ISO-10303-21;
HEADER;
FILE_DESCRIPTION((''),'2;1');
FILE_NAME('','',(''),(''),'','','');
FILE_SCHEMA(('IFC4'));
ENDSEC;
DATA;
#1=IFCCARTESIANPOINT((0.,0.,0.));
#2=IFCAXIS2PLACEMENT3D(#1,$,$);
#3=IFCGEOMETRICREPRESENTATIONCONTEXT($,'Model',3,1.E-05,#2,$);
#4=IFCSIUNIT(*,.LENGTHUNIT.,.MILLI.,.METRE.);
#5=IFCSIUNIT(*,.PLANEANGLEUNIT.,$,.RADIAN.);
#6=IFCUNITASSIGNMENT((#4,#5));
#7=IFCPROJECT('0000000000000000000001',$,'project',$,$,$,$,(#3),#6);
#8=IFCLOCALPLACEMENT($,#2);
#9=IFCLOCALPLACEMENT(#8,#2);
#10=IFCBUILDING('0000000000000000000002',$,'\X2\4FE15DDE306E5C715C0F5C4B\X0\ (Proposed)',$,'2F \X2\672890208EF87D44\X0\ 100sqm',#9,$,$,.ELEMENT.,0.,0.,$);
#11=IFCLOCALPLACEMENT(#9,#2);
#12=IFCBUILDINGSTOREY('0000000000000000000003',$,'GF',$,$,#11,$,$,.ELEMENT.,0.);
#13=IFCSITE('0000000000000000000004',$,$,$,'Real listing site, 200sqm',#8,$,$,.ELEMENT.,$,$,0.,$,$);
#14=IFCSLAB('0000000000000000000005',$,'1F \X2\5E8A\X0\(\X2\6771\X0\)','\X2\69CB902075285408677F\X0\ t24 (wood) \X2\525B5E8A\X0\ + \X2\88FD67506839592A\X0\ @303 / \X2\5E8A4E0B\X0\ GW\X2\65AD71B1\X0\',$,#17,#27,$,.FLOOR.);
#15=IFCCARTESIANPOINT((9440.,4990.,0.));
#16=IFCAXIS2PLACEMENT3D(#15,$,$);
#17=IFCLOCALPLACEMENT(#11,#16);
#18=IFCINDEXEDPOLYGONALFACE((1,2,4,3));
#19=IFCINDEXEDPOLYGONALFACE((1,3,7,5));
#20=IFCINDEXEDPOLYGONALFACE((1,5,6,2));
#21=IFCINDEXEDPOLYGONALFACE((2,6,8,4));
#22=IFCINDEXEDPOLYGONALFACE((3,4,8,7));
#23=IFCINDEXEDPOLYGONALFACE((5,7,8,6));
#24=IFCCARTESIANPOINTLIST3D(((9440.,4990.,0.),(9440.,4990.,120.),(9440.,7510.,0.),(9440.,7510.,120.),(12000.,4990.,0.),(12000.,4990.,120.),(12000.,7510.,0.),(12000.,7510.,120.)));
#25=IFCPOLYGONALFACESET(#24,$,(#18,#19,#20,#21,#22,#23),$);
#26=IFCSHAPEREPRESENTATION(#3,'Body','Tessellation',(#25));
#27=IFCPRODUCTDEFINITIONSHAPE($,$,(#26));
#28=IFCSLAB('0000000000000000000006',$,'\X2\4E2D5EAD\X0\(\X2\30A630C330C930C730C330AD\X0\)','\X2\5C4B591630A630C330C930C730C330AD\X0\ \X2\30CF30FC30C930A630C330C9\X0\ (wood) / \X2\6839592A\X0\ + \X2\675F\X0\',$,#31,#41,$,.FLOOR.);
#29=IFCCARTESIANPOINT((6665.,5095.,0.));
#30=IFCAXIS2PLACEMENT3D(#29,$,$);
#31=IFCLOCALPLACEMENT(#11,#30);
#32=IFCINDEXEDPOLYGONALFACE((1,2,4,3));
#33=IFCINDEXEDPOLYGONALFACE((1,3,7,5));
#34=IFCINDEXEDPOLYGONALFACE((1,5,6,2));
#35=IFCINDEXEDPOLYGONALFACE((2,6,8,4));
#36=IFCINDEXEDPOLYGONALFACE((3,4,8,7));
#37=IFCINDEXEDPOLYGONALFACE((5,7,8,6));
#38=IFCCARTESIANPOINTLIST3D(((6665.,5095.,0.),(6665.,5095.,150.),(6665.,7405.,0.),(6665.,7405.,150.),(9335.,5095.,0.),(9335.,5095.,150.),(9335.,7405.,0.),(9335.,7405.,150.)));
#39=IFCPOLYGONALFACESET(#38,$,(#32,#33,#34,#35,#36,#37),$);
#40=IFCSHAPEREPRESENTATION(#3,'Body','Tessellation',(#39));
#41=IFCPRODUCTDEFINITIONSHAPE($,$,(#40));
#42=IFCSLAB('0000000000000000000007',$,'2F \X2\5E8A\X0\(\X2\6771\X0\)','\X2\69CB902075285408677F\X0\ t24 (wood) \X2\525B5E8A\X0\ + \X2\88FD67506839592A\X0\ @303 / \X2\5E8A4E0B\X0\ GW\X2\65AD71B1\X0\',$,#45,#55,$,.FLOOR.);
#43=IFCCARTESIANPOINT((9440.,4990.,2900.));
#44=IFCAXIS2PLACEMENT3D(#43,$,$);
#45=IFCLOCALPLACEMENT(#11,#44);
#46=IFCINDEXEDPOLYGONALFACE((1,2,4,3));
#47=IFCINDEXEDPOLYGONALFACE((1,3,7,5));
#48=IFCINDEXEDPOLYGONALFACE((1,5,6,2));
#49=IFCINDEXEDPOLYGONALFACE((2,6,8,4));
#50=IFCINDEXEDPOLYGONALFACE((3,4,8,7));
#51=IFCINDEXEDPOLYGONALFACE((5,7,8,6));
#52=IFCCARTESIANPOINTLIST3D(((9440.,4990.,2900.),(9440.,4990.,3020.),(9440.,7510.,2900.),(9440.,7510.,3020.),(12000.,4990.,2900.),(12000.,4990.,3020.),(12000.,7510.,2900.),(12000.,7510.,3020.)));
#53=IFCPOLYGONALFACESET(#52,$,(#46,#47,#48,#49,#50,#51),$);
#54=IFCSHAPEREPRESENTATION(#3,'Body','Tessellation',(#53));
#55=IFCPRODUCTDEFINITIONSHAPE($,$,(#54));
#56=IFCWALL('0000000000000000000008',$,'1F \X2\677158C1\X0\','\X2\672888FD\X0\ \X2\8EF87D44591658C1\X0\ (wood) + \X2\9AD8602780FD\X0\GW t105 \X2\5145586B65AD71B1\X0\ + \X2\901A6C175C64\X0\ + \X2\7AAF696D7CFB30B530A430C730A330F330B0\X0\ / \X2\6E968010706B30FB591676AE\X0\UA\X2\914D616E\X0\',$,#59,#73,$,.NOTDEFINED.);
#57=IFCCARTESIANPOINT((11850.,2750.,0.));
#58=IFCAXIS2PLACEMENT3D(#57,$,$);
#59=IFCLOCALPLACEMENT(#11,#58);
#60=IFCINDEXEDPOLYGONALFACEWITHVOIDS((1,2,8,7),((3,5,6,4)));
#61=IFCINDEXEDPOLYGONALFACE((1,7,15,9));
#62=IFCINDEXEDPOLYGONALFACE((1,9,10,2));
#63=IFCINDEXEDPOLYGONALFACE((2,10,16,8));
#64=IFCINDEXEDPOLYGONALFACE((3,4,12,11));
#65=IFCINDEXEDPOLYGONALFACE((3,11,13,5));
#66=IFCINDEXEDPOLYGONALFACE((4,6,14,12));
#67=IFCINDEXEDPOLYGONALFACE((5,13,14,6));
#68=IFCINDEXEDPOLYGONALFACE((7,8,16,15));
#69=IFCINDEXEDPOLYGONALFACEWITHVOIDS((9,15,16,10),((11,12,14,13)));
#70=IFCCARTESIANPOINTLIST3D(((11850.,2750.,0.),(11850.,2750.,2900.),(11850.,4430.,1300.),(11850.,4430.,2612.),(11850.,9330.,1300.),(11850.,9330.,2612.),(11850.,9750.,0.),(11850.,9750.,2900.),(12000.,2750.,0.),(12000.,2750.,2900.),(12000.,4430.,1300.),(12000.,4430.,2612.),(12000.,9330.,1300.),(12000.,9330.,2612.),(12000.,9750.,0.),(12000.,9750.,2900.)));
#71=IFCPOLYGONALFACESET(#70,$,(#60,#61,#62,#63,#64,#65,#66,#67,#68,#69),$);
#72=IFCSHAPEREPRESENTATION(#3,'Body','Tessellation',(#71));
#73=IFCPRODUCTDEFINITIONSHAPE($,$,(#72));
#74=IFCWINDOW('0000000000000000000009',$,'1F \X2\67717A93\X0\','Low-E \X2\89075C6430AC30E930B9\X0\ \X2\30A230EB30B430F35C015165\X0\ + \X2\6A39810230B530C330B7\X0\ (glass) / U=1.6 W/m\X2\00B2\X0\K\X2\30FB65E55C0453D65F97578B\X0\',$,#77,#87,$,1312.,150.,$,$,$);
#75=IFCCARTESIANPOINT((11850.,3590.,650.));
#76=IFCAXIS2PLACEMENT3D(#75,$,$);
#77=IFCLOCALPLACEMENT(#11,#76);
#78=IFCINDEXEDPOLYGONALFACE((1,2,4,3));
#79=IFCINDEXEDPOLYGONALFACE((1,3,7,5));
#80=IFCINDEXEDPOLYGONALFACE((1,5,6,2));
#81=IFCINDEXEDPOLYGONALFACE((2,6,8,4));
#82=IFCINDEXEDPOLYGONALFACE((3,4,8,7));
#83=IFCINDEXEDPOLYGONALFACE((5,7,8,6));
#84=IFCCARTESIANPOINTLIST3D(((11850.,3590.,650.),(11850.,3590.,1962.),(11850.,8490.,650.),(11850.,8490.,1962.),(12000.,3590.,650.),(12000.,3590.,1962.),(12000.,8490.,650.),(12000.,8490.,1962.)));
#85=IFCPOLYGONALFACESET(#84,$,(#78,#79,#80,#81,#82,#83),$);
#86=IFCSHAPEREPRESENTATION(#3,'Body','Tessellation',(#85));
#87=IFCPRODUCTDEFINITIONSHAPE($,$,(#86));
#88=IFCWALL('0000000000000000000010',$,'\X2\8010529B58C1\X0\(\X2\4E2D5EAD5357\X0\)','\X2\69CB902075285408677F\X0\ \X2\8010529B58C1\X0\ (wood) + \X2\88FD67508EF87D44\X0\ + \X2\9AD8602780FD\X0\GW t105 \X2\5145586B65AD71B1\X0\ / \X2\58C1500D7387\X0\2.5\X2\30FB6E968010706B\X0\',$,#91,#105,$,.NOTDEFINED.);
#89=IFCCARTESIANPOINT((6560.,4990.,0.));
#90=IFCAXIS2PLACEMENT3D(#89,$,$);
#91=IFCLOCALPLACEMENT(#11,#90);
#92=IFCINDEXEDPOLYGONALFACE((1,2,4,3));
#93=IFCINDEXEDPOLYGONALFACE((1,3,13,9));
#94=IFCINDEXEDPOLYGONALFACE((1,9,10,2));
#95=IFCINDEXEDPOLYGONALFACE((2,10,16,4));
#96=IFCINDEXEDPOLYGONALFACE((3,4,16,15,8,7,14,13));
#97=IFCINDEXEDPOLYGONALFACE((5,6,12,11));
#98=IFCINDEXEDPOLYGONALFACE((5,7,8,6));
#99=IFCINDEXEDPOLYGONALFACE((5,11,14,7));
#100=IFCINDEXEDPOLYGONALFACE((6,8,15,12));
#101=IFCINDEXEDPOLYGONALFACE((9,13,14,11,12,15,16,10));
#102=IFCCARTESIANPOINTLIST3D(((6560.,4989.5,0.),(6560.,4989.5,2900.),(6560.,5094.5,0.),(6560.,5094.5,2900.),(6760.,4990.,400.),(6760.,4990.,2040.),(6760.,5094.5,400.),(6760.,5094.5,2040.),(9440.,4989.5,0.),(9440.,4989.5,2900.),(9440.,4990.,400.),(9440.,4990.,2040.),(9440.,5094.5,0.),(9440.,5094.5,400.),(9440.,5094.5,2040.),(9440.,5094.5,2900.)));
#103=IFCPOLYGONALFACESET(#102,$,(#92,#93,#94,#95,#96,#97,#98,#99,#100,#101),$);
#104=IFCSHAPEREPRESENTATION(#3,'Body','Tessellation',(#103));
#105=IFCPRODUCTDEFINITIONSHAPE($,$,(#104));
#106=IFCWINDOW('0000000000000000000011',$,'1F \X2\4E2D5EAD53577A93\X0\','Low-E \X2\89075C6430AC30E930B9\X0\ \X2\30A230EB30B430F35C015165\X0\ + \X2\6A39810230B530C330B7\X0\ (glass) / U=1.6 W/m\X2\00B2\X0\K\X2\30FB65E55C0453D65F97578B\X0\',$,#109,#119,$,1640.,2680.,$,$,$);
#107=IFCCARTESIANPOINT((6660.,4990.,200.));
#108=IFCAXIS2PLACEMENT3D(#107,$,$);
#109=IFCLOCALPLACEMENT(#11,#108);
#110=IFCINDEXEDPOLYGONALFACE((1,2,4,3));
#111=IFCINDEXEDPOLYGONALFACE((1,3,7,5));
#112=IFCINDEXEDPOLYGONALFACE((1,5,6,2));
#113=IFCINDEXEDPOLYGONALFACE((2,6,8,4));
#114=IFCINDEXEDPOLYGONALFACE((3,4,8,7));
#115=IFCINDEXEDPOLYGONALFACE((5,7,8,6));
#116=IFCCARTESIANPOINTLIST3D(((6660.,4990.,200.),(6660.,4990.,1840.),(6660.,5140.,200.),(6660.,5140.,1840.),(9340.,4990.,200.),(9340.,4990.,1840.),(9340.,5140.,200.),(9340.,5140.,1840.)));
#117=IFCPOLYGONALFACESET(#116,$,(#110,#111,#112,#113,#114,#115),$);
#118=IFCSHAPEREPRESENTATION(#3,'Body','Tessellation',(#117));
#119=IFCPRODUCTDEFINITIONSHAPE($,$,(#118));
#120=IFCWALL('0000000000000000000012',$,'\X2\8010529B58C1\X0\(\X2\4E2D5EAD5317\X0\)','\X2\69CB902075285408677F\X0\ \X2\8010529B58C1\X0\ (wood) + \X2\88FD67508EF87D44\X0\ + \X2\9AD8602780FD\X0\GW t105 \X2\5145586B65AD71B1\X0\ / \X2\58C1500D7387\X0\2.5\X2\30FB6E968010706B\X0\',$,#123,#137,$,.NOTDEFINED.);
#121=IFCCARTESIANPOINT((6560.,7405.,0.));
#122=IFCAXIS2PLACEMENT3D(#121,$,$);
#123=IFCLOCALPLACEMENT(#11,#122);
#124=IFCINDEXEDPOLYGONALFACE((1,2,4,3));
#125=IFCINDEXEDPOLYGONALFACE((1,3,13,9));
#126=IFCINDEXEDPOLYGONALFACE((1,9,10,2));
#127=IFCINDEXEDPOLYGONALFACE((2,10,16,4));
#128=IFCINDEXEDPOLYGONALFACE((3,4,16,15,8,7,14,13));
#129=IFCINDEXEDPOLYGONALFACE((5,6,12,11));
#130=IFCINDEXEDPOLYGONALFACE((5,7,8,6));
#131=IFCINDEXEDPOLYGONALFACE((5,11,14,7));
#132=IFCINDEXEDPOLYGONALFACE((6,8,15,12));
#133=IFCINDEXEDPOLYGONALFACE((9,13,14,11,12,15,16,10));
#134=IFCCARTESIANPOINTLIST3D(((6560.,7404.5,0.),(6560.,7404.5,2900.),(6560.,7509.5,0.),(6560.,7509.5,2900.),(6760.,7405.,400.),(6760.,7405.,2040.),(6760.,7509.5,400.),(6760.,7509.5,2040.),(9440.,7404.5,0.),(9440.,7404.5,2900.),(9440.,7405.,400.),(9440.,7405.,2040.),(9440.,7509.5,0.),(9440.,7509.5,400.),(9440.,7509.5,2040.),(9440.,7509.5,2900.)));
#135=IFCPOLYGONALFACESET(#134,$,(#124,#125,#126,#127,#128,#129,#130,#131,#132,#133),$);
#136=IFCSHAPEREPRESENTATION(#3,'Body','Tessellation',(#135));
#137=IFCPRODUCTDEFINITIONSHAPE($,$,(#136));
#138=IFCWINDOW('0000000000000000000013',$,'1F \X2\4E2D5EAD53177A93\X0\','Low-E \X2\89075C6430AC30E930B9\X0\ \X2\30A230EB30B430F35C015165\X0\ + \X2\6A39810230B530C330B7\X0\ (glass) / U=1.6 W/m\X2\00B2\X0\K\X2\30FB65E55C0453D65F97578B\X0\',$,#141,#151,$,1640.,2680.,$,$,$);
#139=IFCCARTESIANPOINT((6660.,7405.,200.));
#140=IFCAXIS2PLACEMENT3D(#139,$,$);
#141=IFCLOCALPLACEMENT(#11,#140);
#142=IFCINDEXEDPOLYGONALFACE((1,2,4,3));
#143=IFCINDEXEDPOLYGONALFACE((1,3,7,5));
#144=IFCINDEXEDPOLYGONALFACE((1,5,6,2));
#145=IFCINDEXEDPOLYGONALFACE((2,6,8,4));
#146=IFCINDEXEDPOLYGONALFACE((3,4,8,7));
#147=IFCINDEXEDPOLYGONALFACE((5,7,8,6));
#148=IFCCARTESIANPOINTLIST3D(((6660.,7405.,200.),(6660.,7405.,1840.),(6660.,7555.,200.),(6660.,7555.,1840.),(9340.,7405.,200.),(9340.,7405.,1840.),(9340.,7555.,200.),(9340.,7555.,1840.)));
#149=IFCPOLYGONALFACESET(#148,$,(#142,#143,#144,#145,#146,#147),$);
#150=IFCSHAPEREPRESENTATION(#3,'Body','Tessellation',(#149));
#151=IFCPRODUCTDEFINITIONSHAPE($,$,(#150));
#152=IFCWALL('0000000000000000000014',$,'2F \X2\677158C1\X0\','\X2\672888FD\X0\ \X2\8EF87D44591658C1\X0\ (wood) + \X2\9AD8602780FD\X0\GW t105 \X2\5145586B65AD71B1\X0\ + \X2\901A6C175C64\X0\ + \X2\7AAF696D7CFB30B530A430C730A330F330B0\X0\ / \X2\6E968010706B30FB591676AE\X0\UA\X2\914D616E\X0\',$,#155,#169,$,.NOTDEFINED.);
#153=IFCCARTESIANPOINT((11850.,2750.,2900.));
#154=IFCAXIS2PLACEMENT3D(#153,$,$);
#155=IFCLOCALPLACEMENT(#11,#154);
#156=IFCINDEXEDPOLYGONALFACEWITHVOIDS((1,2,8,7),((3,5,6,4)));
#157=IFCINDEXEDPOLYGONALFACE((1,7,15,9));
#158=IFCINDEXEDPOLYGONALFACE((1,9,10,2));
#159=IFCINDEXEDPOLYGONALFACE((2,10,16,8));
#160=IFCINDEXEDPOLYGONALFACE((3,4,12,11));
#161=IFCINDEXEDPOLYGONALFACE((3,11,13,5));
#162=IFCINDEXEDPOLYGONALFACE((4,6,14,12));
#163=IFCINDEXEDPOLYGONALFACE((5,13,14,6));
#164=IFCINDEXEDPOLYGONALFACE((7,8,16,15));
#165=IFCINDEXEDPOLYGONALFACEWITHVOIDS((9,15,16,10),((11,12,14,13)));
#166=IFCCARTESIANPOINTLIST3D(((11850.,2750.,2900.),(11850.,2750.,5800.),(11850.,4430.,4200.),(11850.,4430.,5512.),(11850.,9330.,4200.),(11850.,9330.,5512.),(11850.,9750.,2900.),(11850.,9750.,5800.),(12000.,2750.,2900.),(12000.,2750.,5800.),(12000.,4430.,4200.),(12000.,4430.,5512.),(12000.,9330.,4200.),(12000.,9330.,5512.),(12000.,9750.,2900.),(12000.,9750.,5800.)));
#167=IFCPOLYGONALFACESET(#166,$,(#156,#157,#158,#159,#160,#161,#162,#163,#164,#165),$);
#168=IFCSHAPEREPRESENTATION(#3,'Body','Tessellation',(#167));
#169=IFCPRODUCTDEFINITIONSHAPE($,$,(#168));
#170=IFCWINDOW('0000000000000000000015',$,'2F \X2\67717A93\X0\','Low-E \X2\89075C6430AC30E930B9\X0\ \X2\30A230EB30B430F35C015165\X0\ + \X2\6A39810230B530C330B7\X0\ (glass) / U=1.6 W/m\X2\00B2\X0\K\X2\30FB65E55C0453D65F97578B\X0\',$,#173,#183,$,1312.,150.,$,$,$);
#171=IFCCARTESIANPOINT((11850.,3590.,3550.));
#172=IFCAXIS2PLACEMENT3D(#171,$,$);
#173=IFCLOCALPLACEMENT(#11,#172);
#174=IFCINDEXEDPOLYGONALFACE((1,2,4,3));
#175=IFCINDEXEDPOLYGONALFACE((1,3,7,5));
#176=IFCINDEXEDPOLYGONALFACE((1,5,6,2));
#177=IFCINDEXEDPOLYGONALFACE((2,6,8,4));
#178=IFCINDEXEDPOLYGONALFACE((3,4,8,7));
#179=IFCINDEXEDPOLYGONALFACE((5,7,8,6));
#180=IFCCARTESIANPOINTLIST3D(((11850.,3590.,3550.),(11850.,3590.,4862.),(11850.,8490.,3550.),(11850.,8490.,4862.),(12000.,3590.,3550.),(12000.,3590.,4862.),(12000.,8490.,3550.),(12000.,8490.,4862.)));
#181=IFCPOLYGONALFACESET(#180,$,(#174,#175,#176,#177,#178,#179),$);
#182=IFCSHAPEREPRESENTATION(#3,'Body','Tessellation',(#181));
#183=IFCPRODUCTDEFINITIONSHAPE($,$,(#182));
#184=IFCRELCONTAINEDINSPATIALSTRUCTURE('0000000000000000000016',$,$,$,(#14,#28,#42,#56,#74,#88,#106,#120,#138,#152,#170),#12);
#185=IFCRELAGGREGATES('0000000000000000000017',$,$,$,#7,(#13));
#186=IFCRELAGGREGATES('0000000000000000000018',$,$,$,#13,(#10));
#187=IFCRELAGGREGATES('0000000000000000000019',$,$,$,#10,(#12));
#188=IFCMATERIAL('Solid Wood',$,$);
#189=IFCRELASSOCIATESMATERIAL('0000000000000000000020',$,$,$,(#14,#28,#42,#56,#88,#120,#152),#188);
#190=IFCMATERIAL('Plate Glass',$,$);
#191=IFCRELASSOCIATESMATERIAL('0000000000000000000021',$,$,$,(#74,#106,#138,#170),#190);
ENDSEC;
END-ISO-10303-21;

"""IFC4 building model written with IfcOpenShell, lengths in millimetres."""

from ifc_helpers import new_model, si_unit, frame, frame_2d, origin, place, context, project, spatial, rectangle, extrude, material, element, fill, save


model = new_model("IFC4")

# Units and contexts
model_context = context("Model", 3, precision=1e-05, world=origin())
ifc_project = project(units=[si_unit("LENGTHUNIT", "METRE", prefix="MILLI"), si_unit("PLANEANGLEUNIT", "RADIAN")], contexts=[model_context])

# Site, building, storey
site_placement = place(None, origin())
site = spatial("IfcSite", under=ifc_project, at=site_placement, ObjectType="Real listing site, 200sqm", CompositionType="ELEMENT", RefElevation=0.0)
building_placement = place(site_placement, origin())
building = spatial("IfcBuilding", under=site, at=building_placement, Name="信州の山小屋 (Proposed)", ObjectType="2F 木造軸組 100sqm", CompositionType="ELEMENT", ElevationOfRefHeight=0.0, ElevationOfTerrain=0.0)
storey_placement = place(building_placement, origin())
storey = spatial("IfcBuildingStorey", under=building, at=storey_placement, Name="GF", CompositionType="ELEMENT", Elevation=0.0)

# Slabs
ifc_material_1 = material(Name="Solid Wood")
slab_1_placement = place(storey_placement, frame((9440.0, 4990.0, 0.0)))
element("IfcSlab", 1, at=slab_1_placement, inside=storey, material=ifc_material_1, Name="1F 床(東)", Description="構造用合板 t24 (wood) 剛床 + 製材根太 @303 / 床下 GW断熱", PredefinedType="FLOOR", context=model_context, shape_type="SweptSolid", body=[
    extrude(rectangle(XDim=2560.0, YDim=2520.0, at=frame_2d((1280.0, 1260.0))), frame((9440.0, 4990.0, 0.0)), (0.0, 0.0, 1.0), 120.0),
])
slab_2_placement = place(storey_placement, frame((6665.0, 5095.0, 0.0)))
element("IfcSlab", 2, at=slab_2_placement, inside=storey, material=ifc_material_1, Name="中庭(ウッドデッキ)", Description="屋外ウッドデッキ ハードウッド (wood) / 根太 + 束", PredefinedType="FLOOR", context=model_context, shape_type="SweptSolid", body=[
    extrude(rectangle(XDim=2670.0, YDim=2310.0, at=frame_2d((1335.0, 1155.0))), frame((6665.0, 5095.0, 0.0)), (0.0, 0.0, 1.0), 150.0),
])
slab_3_placement = place(storey_placement, frame((9440.0, 4990.0, 2900.0)))
element("IfcSlab", 3, at=slab_3_placement, inside=storey, material=ifc_material_1, Name="2F 床(東)", Description="構造用合板 t24 (wood) 剛床 + 製材根太 @303 / 床下 GW断熱", PredefinedType="FLOOR", context=model_context, shape_type="SweptSolid", body=[
    extrude(rectangle(XDim=2560.0, YDim=2520.0, at=frame_2d((1280.0, 1260.0))), frame((9440.0, 4990.0, 2900.0)), (0.0, 0.0, 1.0), 120.0),
])

# Walls, openings, windows
wall_1_placement = place(storey_placement, frame((11850.0, 2750.0, 0.0)))
wall_1 = element("IfcWall", 4, at=wall_1_placement, inside=storey, material=ifc_material_1, Name="1F 東壁", Description="木製 軸組外壁 (wood) + 高性能GW t105 充填断熱 + 通気層 + 窯業系サイディング / 準耐火・外皮UA配慮", PredefinedType="NOTDEFINED", context=model_context, shape_type="SweptSolid", body=[
    extrude(rectangle(XDim=150.0, YDim=7000.0, at=frame_2d((75.0, 3500.0))), frame((11850.0, 2750.0, 0.0)), (0.0, 0.0, 1.0), 2900.0),
])
opening_1_placement = place(storey_placement, frame((11850.0, 3590.0, 650.0)))
opening_1 = element("IfcOpeningElement", 5, at=opening_1_placement, cuts=wall_1, PredefinedType="NOTDEFINED", context=model_context, shape_type="SweptSolid", body=[
    extrude(rectangle(XDim=150.0, YDim=4900.0, at=frame_2d((75.0, 2450.0))), frame((11850.0, 3590.0, 650.0)), (0.0, 0.0, 1.0), 1312.0),
])
ifc_material_2 = material(Name="Plate Glass")
window_1_placement = place(storey_placement, frame((11850.0, 3590.0, 650.0)))
window_1 = element("IfcWindow", 6, at=window_1_placement, inside=storey, material=ifc_material_2, Name="1F 東窓", Description="Low-E 複層ガラス アルゴン封入 + 樹脂サッシ (glass) / U=1.6 W/m²K・日射取得型", OverallHeight=1312.0, OverallWidth=150.0, context=model_context, shape_type="SweptSolid", body=[
    extrude(rectangle(XDim=150.0, YDim=4900.0, at=frame_2d((75.0, 2450.0))), frame((11850.0, 3590.0, 650.0)), (0.0, 0.0, 1.0), 1312.0),
])
fill(opening_1, window_1)
wall_2_placement = place(storey_placement, frame((6560.0, 4990.0, 0.0)))
wall_2 = element("IfcWall", 7, at=wall_2_placement, inside=storey, material=ifc_material_1, Name="耐力壁(中庭南)", Description="構造用合板 耐力壁 (wood) + 製材軸組 + 高性能GW t105 充填断熱 / 壁倍率2.5・準耐火", PredefinedType="NOTDEFINED", context=model_context, shape_type="SweptSolid", body=[
    extrude(rectangle(XDim=2880.0, YDim=105.0, at=frame_2d((1440.0, 52.0))), frame((6560.0, 4990.0, 0.0)), (0.0, 0.0, 1.0), 2900.0),
])
opening_2_placement = place(storey_placement, frame((6660.0, 4990.0, 200.0)))
opening_2 = element("IfcOpeningElement", 8, at=opening_2_placement, cuts=wall_2, PredefinedType="NOTDEFINED", context=model_context, shape_type="SweptSolid", body=[
    extrude(rectangle(XDim=2680.0, YDim=150.0, at=frame_2d((1340.0, 75.0))), frame((6660.0, 4990.0, 200.0)), (0.0, 0.0, 1.0), 1640.0),
])
window_2_placement = place(storey_placement, frame((6660.0, 4990.0, 200.0)))
window_2 = element("IfcWindow", 9, at=window_2_placement, inside=storey, material=ifc_material_2, Name="1F 中庭南窓", Description="Low-E 複層ガラス アルゴン封入 + 樹脂サッシ (glass) / U=1.6 W/m²K・日射取得型", OverallHeight=1640.0, OverallWidth=2680.0, context=model_context, shape_type="SweptSolid", body=[
    extrude(rectangle(XDim=2680.0, YDim=150.0, at=frame_2d((1340.0, 75.0))), frame((6660.0, 4990.0, 200.0)), (0.0, 0.0, 1.0), 1640.0),
])
fill(opening_2, window_2)
wall_3_placement = place(storey_placement, frame((6560.0, 7405.0, 0.0)))
wall_3 = element("IfcWall", 10, at=wall_3_placement, inside=storey, material=ifc_material_1, Name="耐力壁(中庭北)", Description="構造用合板 耐力壁 (wood) + 製材軸組 + 高性能GW t105 充填断熱 / 壁倍率2.5・準耐火", PredefinedType="NOTDEFINED", context=model_context, shape_type="SweptSolid", body=[
    extrude(rectangle(XDim=2880.0, YDim=105.0, at=frame_2d((1440.0, 52.0))), frame((6560.0, 7405.0, 0.0)), (0.0, 0.0, 1.0), 2900.0),
])
opening_3_placement = place(storey_placement, frame((6660.0, 7405.0, 200.0)))
opening_3 = element("IfcOpeningElement", 11, at=opening_3_placement, cuts=wall_3, PredefinedType="NOTDEFINED", context=model_context, shape_type="SweptSolid", body=[
    extrude(rectangle(XDim=2680.0, YDim=150.0, at=frame_2d((1340.0, 75.0))), frame((6660.0, 7405.0, 200.0)), (0.0, 0.0, 1.0), 1640.0),
])
window_3_placement = place(storey_placement, frame((6660.0, 7405.0, 200.0)))
window_3 = element("IfcWindow", 12, at=window_3_placement, inside=storey, material=ifc_material_2, Name="1F 中庭北窓", Description="Low-E 複層ガラス アルゴン封入 + 樹脂サッシ (glass) / U=1.6 W/m²K・日射取得型", OverallHeight=1640.0, OverallWidth=2680.0, context=model_context, shape_type="SweptSolid", body=[
    extrude(rectangle(XDim=2680.0, YDim=150.0, at=frame_2d((1340.0, 75.0))), frame((6660.0, 7405.0, 200.0)), (0.0, 0.0, 1.0), 1640.0),
])
fill(opening_3, window_3)

# Wall, opening, window
wall_4_placement = place(storey_placement, frame((11850.0, 2750.0, 2900.0)))
wall_4 = element("IfcWall", 13, at=wall_4_placement, inside=storey, material=ifc_material_1, Name="2F 東壁", Description="木製 軸組外壁 (wood) + 高性能GW t105 充填断熱 + 通気層 + 窯業系サイディング / 準耐火・外皮UA配慮", PredefinedType="NOTDEFINED", context=model_context, shape_type="SweptSolid", body=[
    extrude(rectangle(XDim=150.0, YDim=7000.0, at=frame_2d((75.0, 3500.0))), frame((11850.0, 2750.0, 2900.0)), (0.0, 0.0, 1.0), 2900.0),
])
opening_4_placement = place(storey_placement, frame((11850.0, 3590.0, 3550.0)))
opening_4 = element("IfcOpeningElement", 14, at=opening_4_placement, cuts=wall_4, PredefinedType="NOTDEFINED", context=model_context, shape_type="SweptSolid", body=[
    extrude(rectangle(XDim=150.0, YDim=4900.0, at=frame_2d((75.0, 2450.0))), frame((11850.0, 3590.0, 3550.0)), (0.0, 0.0, 1.0), 1312.0),
])
window_4_placement = place(storey_placement, frame((11850.0, 3590.0, 3550.0)))
window_4 = element("IfcWindow", 15, at=window_4_placement, inside=storey, material=ifc_material_2, Name="2F 東窓", Description="Low-E 複層ガラス アルゴン封入 + 樹脂サッシ (glass) / U=1.6 W/m²K・日射取得型", OverallHeight=1312.0, OverallWidth=150.0, context=model_context, shape_type="SweptSolid", body=[
    extrude(rectangle(XDim=150.0, YDim=4900.0, at=frame_2d((75.0, 2450.0))), frame((11850.0, 3590.0, 3550.0)), (0.0, 0.0, 1.0), 1312.0),
])
fill(opening_4, window_4)

save(model, "model.ifc")
